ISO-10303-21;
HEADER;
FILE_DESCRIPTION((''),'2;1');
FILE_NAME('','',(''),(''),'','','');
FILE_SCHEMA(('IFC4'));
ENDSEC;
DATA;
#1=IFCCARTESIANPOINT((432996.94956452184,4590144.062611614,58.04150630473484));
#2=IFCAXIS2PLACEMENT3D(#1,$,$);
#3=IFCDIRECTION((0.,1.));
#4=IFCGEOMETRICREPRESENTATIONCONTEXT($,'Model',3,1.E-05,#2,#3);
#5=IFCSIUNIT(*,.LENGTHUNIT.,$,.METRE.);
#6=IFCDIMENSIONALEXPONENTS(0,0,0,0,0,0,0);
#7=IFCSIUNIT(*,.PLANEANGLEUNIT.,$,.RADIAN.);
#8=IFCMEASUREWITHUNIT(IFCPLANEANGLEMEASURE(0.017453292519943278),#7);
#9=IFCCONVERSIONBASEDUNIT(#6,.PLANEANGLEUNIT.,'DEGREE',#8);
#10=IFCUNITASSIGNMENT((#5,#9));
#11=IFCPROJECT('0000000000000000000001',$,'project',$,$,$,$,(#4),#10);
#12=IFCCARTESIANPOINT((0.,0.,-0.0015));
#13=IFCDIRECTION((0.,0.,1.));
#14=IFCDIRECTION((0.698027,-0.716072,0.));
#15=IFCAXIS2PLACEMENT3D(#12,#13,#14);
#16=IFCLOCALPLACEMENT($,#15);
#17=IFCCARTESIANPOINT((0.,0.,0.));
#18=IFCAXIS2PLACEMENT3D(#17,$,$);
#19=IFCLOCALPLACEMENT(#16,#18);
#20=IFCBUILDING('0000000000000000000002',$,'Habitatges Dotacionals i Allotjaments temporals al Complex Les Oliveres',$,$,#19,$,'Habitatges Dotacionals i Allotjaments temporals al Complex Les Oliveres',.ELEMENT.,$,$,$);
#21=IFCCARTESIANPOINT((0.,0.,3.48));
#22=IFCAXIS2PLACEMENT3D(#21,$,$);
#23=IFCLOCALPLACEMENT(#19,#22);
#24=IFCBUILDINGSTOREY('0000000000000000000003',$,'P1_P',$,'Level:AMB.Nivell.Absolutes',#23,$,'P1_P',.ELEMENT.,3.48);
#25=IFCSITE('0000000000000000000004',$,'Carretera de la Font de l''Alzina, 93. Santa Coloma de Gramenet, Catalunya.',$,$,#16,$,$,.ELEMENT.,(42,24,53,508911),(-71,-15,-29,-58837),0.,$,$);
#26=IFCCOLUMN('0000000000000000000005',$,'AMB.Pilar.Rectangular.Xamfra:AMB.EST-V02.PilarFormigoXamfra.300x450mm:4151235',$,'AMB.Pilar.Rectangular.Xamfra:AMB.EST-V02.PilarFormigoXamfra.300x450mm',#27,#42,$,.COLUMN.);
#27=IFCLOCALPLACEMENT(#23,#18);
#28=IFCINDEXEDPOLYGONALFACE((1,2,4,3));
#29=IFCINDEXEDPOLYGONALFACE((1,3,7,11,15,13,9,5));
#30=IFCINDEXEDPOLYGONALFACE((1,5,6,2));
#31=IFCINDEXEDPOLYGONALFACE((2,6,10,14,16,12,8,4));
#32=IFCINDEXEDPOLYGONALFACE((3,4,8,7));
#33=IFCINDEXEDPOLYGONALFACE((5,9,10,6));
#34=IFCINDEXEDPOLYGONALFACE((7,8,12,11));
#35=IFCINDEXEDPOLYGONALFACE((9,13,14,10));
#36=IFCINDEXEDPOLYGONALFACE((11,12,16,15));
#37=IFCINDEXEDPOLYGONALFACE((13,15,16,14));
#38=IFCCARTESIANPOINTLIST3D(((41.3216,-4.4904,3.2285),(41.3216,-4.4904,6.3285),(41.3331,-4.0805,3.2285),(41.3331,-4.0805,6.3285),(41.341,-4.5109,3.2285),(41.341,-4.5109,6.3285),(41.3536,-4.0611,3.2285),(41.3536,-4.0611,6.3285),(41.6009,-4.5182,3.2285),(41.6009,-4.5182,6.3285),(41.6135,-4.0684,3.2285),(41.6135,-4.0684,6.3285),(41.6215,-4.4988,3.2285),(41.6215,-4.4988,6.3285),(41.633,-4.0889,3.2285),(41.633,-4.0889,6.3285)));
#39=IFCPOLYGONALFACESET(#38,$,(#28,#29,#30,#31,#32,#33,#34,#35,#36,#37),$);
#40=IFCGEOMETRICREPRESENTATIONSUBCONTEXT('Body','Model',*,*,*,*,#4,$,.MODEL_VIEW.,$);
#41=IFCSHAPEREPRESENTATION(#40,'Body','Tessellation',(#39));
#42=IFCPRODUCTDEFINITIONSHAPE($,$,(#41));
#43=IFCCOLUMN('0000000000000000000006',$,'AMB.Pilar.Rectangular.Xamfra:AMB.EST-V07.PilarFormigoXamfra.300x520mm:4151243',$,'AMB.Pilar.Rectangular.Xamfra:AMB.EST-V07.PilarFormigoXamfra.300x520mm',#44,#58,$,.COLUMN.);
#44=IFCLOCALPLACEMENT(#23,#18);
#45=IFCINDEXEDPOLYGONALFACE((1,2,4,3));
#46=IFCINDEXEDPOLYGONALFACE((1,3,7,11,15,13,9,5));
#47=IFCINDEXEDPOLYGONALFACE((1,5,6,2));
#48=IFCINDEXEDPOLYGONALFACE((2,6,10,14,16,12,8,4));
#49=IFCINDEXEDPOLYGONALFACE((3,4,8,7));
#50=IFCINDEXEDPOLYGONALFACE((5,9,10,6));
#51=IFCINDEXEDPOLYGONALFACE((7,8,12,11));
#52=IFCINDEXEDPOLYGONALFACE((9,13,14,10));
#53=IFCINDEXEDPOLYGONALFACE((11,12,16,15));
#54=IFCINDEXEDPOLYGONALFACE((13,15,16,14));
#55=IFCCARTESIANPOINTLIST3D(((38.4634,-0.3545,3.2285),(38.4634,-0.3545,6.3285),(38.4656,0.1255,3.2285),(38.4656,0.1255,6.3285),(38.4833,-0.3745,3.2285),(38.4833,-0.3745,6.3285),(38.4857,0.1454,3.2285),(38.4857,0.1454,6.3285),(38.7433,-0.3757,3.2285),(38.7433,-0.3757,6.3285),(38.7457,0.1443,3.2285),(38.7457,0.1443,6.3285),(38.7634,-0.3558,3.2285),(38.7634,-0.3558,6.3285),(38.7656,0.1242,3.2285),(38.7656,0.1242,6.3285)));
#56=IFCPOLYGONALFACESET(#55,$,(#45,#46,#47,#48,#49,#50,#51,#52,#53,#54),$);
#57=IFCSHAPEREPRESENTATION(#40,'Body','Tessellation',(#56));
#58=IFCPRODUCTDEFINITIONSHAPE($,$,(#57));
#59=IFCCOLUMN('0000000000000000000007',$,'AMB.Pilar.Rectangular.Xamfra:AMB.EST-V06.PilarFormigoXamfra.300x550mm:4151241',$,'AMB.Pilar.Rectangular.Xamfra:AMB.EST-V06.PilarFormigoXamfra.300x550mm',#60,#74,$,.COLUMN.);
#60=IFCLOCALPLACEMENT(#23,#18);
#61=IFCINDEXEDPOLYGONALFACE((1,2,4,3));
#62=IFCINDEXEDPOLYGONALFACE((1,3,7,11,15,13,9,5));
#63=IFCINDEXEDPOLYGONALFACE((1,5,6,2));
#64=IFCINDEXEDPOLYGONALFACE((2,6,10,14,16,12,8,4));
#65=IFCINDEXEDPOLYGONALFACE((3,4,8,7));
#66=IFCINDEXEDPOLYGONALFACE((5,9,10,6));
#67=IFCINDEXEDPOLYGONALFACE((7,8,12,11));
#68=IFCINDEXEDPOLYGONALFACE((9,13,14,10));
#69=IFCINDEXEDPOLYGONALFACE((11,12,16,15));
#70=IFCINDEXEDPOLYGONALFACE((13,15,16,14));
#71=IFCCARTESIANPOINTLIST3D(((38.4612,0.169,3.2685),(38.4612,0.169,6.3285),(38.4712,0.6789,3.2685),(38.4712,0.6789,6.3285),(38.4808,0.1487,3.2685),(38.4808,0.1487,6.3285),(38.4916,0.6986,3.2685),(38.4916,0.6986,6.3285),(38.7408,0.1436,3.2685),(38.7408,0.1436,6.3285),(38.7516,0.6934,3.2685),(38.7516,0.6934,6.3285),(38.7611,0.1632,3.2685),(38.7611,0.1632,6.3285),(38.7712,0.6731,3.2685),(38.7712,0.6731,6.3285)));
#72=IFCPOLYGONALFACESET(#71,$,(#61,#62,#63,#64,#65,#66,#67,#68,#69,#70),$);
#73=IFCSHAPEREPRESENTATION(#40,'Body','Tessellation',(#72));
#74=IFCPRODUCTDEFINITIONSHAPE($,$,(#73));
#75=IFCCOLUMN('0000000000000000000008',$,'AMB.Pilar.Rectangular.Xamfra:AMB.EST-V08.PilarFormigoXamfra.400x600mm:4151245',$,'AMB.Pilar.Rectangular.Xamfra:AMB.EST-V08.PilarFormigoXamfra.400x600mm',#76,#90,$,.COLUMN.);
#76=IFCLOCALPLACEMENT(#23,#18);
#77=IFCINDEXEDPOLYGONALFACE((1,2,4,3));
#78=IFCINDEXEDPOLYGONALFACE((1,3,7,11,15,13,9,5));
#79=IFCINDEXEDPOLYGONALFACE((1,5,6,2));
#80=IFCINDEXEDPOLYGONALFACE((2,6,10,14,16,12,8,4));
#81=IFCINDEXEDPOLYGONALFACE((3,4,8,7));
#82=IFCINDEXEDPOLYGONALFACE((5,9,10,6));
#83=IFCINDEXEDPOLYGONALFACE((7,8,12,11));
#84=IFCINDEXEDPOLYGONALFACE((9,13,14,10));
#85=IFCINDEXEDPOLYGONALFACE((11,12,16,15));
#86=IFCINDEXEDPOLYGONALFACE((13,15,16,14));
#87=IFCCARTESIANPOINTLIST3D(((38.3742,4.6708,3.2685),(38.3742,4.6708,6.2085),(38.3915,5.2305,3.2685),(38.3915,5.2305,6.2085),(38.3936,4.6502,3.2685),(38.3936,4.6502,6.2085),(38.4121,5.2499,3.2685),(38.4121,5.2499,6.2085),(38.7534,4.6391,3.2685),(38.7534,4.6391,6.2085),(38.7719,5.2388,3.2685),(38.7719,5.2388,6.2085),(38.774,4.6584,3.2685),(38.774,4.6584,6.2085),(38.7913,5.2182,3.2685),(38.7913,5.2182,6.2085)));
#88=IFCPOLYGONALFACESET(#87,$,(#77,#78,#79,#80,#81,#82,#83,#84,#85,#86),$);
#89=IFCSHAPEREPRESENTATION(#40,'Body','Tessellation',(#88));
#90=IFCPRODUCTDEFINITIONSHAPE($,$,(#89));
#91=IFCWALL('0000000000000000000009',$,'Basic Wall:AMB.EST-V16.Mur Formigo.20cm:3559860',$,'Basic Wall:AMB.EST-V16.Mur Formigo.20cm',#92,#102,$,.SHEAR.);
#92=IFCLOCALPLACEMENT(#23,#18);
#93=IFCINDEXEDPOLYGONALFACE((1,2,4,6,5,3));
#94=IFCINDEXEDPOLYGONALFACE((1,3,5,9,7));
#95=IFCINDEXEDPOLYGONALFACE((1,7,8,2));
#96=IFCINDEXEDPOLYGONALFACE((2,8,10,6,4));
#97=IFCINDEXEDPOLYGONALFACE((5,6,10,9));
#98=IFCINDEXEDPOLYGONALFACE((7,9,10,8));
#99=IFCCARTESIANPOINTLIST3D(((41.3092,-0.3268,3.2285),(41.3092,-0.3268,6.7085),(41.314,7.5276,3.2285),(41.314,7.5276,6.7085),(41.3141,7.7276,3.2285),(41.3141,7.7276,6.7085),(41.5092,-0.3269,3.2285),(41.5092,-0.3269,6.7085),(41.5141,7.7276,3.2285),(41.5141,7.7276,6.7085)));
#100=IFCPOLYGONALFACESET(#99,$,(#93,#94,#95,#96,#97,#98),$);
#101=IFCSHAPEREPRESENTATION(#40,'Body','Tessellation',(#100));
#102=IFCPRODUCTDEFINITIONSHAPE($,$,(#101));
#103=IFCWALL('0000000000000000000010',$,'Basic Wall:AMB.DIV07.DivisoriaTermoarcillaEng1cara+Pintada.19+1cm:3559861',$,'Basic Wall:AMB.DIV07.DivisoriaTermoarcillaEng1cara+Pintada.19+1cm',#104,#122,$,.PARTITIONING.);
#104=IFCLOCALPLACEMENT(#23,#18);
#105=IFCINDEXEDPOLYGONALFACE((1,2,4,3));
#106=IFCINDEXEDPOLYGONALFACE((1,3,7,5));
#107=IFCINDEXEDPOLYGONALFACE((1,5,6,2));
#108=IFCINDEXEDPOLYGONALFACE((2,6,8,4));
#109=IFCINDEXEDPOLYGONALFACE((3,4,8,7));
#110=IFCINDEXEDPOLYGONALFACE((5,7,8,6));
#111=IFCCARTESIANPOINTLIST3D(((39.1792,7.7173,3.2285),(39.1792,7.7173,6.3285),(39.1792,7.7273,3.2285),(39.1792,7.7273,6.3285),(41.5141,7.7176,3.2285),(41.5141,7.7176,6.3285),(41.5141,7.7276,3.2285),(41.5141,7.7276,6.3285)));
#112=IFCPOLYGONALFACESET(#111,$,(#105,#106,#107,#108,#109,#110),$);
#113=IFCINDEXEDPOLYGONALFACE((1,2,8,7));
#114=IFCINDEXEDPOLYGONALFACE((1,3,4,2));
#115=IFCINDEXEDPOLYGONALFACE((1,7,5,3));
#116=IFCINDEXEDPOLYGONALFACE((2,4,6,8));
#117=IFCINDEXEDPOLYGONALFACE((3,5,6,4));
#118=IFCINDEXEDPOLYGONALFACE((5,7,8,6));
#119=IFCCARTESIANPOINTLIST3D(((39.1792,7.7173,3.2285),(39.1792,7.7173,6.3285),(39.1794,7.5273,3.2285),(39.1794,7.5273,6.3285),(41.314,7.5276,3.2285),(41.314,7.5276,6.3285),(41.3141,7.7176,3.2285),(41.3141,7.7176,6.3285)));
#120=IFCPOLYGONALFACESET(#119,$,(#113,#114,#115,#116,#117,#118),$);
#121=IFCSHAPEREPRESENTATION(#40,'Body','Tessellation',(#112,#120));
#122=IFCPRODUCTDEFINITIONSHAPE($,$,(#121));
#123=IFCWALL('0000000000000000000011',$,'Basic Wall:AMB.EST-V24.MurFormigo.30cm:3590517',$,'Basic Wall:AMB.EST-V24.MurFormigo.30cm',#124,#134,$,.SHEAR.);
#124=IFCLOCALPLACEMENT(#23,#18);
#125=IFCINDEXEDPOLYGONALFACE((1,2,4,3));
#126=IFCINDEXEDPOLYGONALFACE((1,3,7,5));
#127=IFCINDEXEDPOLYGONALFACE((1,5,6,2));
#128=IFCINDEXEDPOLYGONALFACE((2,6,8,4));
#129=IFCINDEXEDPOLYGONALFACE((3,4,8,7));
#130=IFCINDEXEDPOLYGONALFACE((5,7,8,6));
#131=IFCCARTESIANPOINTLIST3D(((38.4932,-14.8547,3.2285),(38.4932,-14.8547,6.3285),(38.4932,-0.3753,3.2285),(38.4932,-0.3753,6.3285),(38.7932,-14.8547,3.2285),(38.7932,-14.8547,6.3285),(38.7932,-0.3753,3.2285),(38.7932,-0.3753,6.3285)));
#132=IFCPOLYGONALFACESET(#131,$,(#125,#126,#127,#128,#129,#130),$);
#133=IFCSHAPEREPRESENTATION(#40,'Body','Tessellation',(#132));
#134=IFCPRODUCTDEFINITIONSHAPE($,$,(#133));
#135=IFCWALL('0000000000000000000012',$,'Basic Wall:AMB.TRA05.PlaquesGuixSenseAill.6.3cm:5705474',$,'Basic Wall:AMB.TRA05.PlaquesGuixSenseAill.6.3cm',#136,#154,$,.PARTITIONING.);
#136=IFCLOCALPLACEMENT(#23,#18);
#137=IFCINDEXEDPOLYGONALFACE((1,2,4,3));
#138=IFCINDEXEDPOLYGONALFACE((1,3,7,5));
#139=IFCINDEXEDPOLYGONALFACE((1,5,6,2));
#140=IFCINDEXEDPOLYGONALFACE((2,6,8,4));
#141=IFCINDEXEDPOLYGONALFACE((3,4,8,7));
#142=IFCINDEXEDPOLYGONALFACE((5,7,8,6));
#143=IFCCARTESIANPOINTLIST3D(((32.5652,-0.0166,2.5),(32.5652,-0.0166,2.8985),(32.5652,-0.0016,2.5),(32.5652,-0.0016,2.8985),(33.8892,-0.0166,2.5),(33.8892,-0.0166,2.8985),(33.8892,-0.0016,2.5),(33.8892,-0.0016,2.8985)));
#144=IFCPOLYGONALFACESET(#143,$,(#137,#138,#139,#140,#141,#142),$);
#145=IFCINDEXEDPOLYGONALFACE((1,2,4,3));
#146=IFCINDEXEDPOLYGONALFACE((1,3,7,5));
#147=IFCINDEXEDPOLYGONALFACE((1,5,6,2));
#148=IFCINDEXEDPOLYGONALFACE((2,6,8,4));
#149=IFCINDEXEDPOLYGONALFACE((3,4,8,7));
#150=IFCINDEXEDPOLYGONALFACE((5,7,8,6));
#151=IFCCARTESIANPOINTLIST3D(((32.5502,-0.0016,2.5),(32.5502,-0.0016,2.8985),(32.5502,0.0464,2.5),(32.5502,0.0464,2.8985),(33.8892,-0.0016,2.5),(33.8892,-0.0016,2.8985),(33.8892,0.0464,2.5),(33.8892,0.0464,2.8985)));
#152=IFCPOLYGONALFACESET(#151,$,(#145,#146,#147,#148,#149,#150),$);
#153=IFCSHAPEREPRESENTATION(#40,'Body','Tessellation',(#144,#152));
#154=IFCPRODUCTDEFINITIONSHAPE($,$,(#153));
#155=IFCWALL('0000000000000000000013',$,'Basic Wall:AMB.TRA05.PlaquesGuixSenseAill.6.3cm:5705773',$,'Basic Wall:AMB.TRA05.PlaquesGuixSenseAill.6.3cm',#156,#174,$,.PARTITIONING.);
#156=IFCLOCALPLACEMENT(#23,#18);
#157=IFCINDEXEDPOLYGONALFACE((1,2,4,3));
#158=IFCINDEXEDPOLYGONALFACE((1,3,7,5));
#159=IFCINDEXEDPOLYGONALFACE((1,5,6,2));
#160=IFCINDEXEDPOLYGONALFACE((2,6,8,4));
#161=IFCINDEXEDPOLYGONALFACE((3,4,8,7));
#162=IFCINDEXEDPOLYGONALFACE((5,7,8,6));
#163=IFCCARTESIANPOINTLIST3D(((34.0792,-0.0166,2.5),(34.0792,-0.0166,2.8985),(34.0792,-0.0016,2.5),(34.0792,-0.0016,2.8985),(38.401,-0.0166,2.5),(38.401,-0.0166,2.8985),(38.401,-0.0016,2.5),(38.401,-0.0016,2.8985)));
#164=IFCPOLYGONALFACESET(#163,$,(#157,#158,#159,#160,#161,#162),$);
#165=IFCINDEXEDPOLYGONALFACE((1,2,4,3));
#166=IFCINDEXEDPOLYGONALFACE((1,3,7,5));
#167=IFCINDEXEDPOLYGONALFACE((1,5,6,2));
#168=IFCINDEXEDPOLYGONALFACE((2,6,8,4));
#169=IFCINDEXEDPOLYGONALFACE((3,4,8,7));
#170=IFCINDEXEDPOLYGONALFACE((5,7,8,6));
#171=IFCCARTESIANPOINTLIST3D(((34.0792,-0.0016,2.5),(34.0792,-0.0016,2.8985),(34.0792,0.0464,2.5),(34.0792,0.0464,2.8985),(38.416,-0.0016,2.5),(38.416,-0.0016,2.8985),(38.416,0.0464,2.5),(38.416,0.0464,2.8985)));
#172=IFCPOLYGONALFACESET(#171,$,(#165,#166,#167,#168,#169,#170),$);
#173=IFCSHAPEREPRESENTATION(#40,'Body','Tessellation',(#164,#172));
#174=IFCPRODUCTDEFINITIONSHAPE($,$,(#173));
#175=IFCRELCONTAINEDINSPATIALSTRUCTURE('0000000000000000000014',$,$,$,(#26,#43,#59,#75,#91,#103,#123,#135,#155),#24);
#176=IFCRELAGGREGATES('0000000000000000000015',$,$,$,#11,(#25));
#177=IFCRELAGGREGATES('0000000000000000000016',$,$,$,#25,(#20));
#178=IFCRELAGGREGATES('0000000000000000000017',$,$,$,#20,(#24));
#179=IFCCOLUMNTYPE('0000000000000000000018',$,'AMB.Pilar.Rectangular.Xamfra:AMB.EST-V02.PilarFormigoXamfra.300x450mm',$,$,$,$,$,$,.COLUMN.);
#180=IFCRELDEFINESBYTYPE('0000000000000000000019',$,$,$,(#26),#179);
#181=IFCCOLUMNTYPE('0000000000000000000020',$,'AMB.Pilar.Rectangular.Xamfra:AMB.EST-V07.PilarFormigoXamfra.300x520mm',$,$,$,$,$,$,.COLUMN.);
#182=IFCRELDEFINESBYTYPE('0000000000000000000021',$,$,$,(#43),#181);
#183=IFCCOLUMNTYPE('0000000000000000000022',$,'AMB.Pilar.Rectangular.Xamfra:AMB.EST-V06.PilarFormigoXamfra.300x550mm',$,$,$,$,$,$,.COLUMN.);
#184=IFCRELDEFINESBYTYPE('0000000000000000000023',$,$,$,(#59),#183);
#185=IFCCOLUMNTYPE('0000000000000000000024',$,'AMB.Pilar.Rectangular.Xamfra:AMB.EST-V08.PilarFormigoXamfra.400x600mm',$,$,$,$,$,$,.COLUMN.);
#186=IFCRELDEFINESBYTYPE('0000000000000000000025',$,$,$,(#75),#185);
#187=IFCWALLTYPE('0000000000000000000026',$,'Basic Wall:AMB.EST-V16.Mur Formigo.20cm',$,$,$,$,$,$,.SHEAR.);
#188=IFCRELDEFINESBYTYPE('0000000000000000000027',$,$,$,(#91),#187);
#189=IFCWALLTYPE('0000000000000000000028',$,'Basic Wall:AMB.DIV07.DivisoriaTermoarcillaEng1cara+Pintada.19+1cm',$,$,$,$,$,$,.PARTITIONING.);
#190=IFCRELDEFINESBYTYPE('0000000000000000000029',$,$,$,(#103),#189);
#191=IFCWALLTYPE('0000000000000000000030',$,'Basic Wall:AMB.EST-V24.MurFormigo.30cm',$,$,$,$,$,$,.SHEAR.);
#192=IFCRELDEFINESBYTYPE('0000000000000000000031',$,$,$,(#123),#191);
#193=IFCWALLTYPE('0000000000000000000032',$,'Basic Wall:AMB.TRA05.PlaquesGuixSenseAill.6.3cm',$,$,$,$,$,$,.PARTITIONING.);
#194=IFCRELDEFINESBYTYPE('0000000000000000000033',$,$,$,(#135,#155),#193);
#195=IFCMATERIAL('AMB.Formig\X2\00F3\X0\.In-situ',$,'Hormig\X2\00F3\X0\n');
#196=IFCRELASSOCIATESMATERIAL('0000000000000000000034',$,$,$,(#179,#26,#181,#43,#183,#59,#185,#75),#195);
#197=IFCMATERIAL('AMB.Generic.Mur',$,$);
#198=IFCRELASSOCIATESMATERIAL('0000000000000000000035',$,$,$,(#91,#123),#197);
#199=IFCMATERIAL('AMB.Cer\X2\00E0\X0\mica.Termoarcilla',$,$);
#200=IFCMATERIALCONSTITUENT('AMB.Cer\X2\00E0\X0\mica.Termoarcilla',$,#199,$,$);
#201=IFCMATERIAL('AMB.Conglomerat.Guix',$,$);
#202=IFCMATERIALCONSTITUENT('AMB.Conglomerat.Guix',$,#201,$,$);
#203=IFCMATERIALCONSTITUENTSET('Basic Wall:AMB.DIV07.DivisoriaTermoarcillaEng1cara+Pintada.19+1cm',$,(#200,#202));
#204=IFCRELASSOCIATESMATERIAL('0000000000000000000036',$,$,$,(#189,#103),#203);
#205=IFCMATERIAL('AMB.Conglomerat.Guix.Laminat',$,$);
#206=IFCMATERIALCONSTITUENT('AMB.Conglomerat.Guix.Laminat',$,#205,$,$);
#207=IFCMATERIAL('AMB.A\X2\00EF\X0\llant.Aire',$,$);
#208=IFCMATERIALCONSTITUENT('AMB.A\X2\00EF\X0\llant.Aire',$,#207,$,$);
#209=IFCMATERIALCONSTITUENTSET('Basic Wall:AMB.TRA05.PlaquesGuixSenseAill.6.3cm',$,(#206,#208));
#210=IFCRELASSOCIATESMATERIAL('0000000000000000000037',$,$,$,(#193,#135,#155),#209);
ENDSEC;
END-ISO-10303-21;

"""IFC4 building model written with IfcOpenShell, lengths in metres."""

from ifc_helpers import new_model, entity, si_unit, converted_unit, direction, frame, origin, place, context, subcontext, project, spatial, indexed_curve, outline, extrude, source, transform, mapped, material, constituent, constituent_set, type_object, type_shapes, element, save


model = new_model("IFC4")

# Units and contexts
model_context = context("Model", 3, precision=1e-05, world=frame((432996.94956452184, 4590144.062611614, 58.04150630473484)), true_north=direction((0.0, 1.0)))
body_context = subcontext(model_context, "Body", "Model", "MODEL_VIEW")
ifc_project = project(units=[si_unit("LENGTHUNIT", "METRE"), converted_unit("PLANEANGLEUNIT", "DEGREE", entity("IfcPlaneAngleMeasure", 0.017453292519943278), si_unit("PLANEANGLEUNIT", "RADIAN"), dimensions=[0, 0, 0, 0, 0, 0, 0])], contexts=[model_context])

# Site, building, storey
site_placement = place(None, frame((0.0, 0.0, -0.0015), z_axis=(0.0, 0.0, 1.0), x_axis=(0.698027, -0.716072, 0.0)))
site = spatial("IfcSite", under=ifc_project, at=site_placement, Name="Carretera de la Font de l'Alzina, 93. Santa Coloma de Gramenet, Catalunya.", CompositionType="ELEMENT", RefLatitude=(42, 24, 53, 508911), RefLongitude=(-71, -15, -29, -58837), RefElevation=0.0)
building_placement = place(site_placement, origin())
building = spatial("IfcBuilding", under=site, at=building_placement, Name="Habitatges Dotacionals i Allotjaments temporals al Complex Les Oliveres", LongName="Habitatges Dotacionals i Allotjaments temporals al Complex Les Oliveres", CompositionType="ELEMENT")
storey_placement = place(building_placement, frame((0.0, 0.0, 3.48)))
storey = spatial("IfcBuildingStorey", under=building, at=storey_placement, Name="P1_P", ObjectType="Level:AMB.Nivell.Absolutes", LongName="P1_P", CompositionType="ELEMENT", Elevation=3.48)

# Columns
ifc_material_1 = material(Name="AMB.Formigó.In-situ", Category="Hormigón")
column_type_1 = type_object("IfcColumnType", Name="AMB.Pilar.Rectangular.Xamfra:AMB.EST-V02.PilarFormigoXamfra.300x450mm", PredefinedType="COLUMN", material=ifc_material_1)
shared_shape_1 = source(origin(), body_context, "Body", "SweptSolid", [
    extrude(outline(indexed_curve([(-0.13, -0.225), (0.13, -0.225), (0.15, -0.205), (0.15, 0.205), (0.13, 0.225), (-0.13, 0.225), (-0.15, 0.205), (-0.15, -0.205), (-0.13, -0.225)], self_intersect=False)), frame((0.0, 0.0, 6.7085), z_axis=(0.0, 0.0, 1.0), x_axis=(-1.0, 0.0, 0.0)), (0.0, 0.0, 1.0), 3.1),
])
type_shapes(column_type_1, [shared_shape_1])
column_1_placement = place(storey_placement, frame((41.4773, -4.2896, -3.48), z_axis=(0.0, 0.0, 1.0), x_axis=(0.999609, -0.027977, 0.0)))
element("IfcColumn", 1, at=column_1_placement, inside=storey, type_object=column_type_1, material=ifc_material_1, Name="AMB.Pilar.Rectangular.Xamfra:AMB.EST-V02.PilarFormigoXamfra.300x450mm:4151235", ObjectType="AMB.Pilar.Rectangular.Xamfra:AMB.EST-V02.PilarFormigoXamfra.300x450mm", PredefinedType="COLUMN", context=body_context, shape_type="MappedRepresentation", body=[
    mapped(shared_shape_1, transform((0.0, 0.0, 0.0), scale=1.0)),
])
column_type_2 = type_object("IfcColumnType", Name="AMB.Pilar.Rectangular.Xamfra:AMB.EST-V07.PilarFormigoXamfra.300x520mm", PredefinedType="COLUMN", material=ifc_material_1)
shared_shape_2 = source(origin(), body_context, "Body", "SweptSolid", [
    extrude(outline(indexed_curve([(-0.13, -0.26), (0.13, -0.26), (0.15, -0.24), (0.15, 0.24), (0.13, 0.26), (-0.13, 0.26), (-0.15, 0.24), (-0.15, -0.24), (-0.13, -0.26)], self_intersect=False)), frame((0.0, 0.0, 6.7085), z_axis=(0.0, 0.0, 1.0), x_axis=(-1.0, 0.0, 0.0)), (0.0, 0.0, 1.0), 3.1),
])
type_shapes(column_type_2, [shared_shape_2])
column_2_placement = place(storey_placement, frame((38.6145, -0.1151, -3.48), z_axis=(0.0, 0.0, 1.0), x_axis=(0.999989, -0.004594, 0.0)))
element("IfcColumn", 2, at=column_2_placement, inside=storey, type_object=column_type_2, material=ifc_material_1, Name="AMB.Pilar.Rectangular.Xamfra:AMB.EST-V07.PilarFormigoXamfra.300x520mm:4151243", ObjectType="AMB.Pilar.Rectangular.Xamfra:AMB.EST-V07.PilarFormigoXamfra.300x520mm", PredefinedType="COLUMN", context=body_context, shape_type="MappedRepresentation", body=[
    mapped(shared_shape_2, transform((0.0, 0.0, 0.0), scale=1.0)),
])
column_type_3 = type_object("IfcColumnType", Name="AMB.Pilar.Rectangular.Xamfra:AMB.EST-V06.PilarFormigoXamfra.300x550mm", PredefinedType="COLUMN", material=ifc_material_1)
shared_shape_3 = source(origin(), body_context, "Body", "SweptSolid", [
    extrude(outline(indexed_curve([(-0.13, -0.275), (0.13, -0.275), (0.15, -0.255), (0.15, 0.255), (0.13, 0.275), (-0.13, 0.275), (-0.15, 0.255), (-0.15, -0.255), (-0.13, -0.275)], self_intersect=False)), frame((0.0, 0.0, 6.7485), z_axis=(0.0, 0.0, 1.0), x_axis=(-1.0, 0.0, 0.0)), (0.0, 0.0, 1.0), 3.06),
])
type_shapes(column_type_3, [shared_shape_3])
column_3_placement = place(storey_placement, frame((38.6162, 0.4211, -3.48), z_axis=(0.0, 0.0, 1.0), x_axis=(0.999807, -0.019634, 0.0)))
element("IfcColumn", 3, at=column_3_placement, inside=storey, type_object=column_type_3, material=ifc_material_1, Name="AMB.Pilar.Rectangular.Xamfra:AMB.EST-V06.PilarFormigoXamfra.300x550mm:4151241", ObjectType="AMB.Pilar.Rectangular.Xamfra:AMB.EST-V06.PilarFormigoXamfra.300x550mm", PredefinedType="COLUMN", context=body_context, shape_type="MappedRepresentation", body=[
    mapped(shared_shape_3, transform((0.0, 0.0, 0.0), scale=1.0)),
])
column_type_4 = type_object("IfcColumnType", Name="AMB.Pilar.Rectangular.Xamfra:AMB.EST-V08.PilarFormigoXamfra.400x600mm", PredefinedType="COLUMN", material=ifc_material_1)
shared_shape_4 = source(origin(), body_context, "Body", "SweptSolid", [
    extrude(outline(indexed_curve([(-0.18, -0.3), (0.18, -0.3), (0.2, -0.28), (0.2, 0.28), (0.18, 0.3), (-0.18, 0.3), (-0.2, 0.28), (-0.2, -0.28), (-0.18, -0.3)], self_intersect=False)), frame((0.0, 0.0, 6.7485), z_axis=(0.0, 0.0, 1.0), x_axis=(-1.0, 0.0, 0.0)), (0.0, 0.0, 1.0), 2.94),
])
type_shapes(column_type_4, [shared_shape_4])
column_4_placement = place(storey_placement, frame((38.5827, 4.9445, -3.48), z_axis=(0.0, 0.0, 1.0), x_axis=(-0.999523, 0.030873, 0.0)))
element("IfcColumn", 4, at=column_4_placement, inside=storey, type_object=column_type_4, material=ifc_material_1, Name="AMB.Pilar.Rectangular.Xamfra:AMB.EST-V08.PilarFormigoXamfra.400x600mm:4151245", ObjectType="AMB.Pilar.Rectangular.Xamfra:AMB.EST-V08.PilarFormigoXamfra.400x600mm", PredefinedType="COLUMN", context=body_context, shape_type="MappedRepresentation", body=[
    mapped(shared_shape_4, transform((0.0, 0.0, 0.0), scale=1.0)),
])

# Walls
ifc_material_2 = material(Name="AMB.Generic.Mur")
wall_type_1 = type_object("IfcWallType", Name="Basic Wall:AMB.EST-V16.Mur Formigo.20cm", PredefinedType="SHEAR")
wall_1_placement = place(storey_placement, frame((41.4092, -0.3269, 3.2285), z_axis=(0.0, 0.0, 1.0), x_axis=(0.000611, 1.0, 0.0)))
element("IfcWall", 5, at=wall_1_placement, inside=storey, type_object=wall_type_1, material=ifc_material_2, Name="Basic Wall:AMB.EST-V16.Mur Formigo.20cm:3559860", ObjectType="Basic Wall:AMB.EST-V16.Mur Formigo.20cm", PredefinedType="SHEAR", context=body_context, shape_type="SweptSolid", body=[
    extrude(outline(indexed_curve([(8.0546, -0.1), (8.0544, 0.1), (7.8544, 0.1), (0.0, 0.1), (0.0, -0.1), (8.0546, -0.1)], self_intersect=False)), origin(), (0.0, 0.0, 1.0), 3.48),
])
ifc_material_3 = material(Name="AMB.Ceràmica.Termoarcilla")
ifc_constituent_1 = constituent(ifc_material_3, Name="AMB.Ceràmica.Termoarcilla")
ifc_material_4 = material(Name="AMB.Conglomerat.Guix")
ifc_constituent_2 = constituent(ifc_material_4, Name="AMB.Conglomerat.Guix")
ifc_constituent_set_1 = constituent_set(constituents=[ifc_constituent_1, ifc_constituent_2], Name="Basic Wall:AMB.DIV07.DivisoriaTermoarcillaEng1cara+Pintada.19+1cm")
wall_type_2 = type_object("IfcWallType", Name="Basic Wall:AMB.DIV07.DivisoriaTermoarcillaEng1cara+Pintada.19+1cm", PredefinedType="PARTITIONING", material=ifc_constituent_set_1)
wall_2_placement = place(storey_placement, frame((41.3141, 7.6276, 3.2285), z_axis=(0.0, 0.0, 1.0), x_axis=(-1.0, -0.000147, 0.0)))
element("IfcWall", 6, at=wall_2_placement, inside=storey, type_object=wall_type_2, material=ifc_constituent_set_1, Name="Basic Wall:AMB.DIV07.DivisoriaTermoarcillaEng1cara+Pintada.19+1cm:3559861", ObjectType="Basic Wall:AMB.DIV07.DivisoriaTermoarcillaEng1cara+Pintada.19+1cm", PredefinedType="PARTITIONING", context=body_context, shape_type="SweptSolid", body=[
    extrude(outline(indexed_curve([(-0.0061, -1.1674), (0.0039, -1.1674), (0.0061, 1.1674), (-0.0039, 1.1675), (-0.0061, -1.1674)], self_intersect=False)), frame((0.9675, -0.095, 0.0), z_axis=(0.0, 0.0, 1.0), x_axis=(-0.00093, 1.0, 0.0)), (0.0, 0.0, 1.0), 3.1),
    extrude(outline(indexed_curve([(-0.0942, -1.0674), (0.0958, -1.0674), (0.0942, 1.0675), (-0.0958, 1.0672), (-0.0942, -1.0674)], self_intersect=False)), frame((1.0674, 0.005, 0.0), z_axis=(0.0, 0.0, 1.0), x_axis=(-0.000759, -1.0, 0.0)), (0.0, 0.0, 1.0), 3.1),
])

# Walls
wall_type_3 = type_object("IfcWallType", Name="Basic Wall:AMB.EST-V24.MurFormigo.30cm", PredefinedType="SHEAR")
wall_3_placement = place(storey_placement, frame((38.6432, -0.3753, 3.2285), z_axis=(0.0, 0.0, 1.0), x_axis=(0.0, -1.0, 0.0)))
element("IfcWall", 7, at=wall_3_placement, inside=storey, type_object=wall_type_3, material=ifc_material_2, Name="Basic Wall:AMB.EST-V24.MurFormigo.30cm:3590517", ObjectType="Basic Wall:AMB.EST-V24.MurFormigo.30cm", PredefinedType="SHEAR", context=body_context, shape_type="SweptSolid", body=[
    extrude(outline(indexed_curve([(14.4794, 0.15), (0.0, 0.15), (0.0, -0.15), (14.4794, -0.15), (14.4794, 0.15)], self_intersect=False)), origin(), (0.0, 0.0, 1.0), 3.1),
])
ifc_material_5 = material(Name="AMB.Conglomerat.Guix.Laminat")
ifc_constituent_3 = constituent(ifc_material_5, Name="AMB.Conglomerat.Guix.Laminat")
ifc_material_6 = material(Name="AMB.Aïllant.Aire")
ifc_constituent_4 = constituent(ifc_material_6, Name="AMB.Aïllant.Aire")
ifc_constituent_set_2 = constituent_set(constituents=[ifc_constituent_3, ifc_constituent_4], Name="Basic Wall:AMB.TRA05.PlaquesGuixSenseAill.6.3cm")
wall_type_4 = type_object("IfcWallType", Name="Basic Wall:AMB.TRA05.PlaquesGuixSenseAill.6.3cm", PredefinedType="PARTITIONING", material=ifc_constituent_set_2)
wall_4_placement = place(storey_placement, frame((33.8792, 0.0149, 2.5), z_axis=(0.0, 0.0, 1.0), x_axis=(-1.0, 0.0, 0.0)))
element("IfcWall", 8, at=wall_4_placement, inside=storey, type_object=wall_type_4, material=ifc_constituent_set_2, Name="Basic Wall:AMB.TRA05.PlaquesGuixSenseAill.6.3cm:5705474", ObjectType="Basic Wall:AMB.TRA05.PlaquesGuixSenseAill.6.3cm", PredefinedType="PARTITIONING", context=body_context, shape_type="SweptSolid", body=[
    extrude(outline(indexed_curve([(-0.0075, -0.662), (0.0075, -0.662), (0.0075, 0.662), (-0.0075, 0.662), (-0.0075, -0.662)], self_intersect=False)), frame((0.652, 0.024, 0.0), z_axis=(0.0, 0.0, 1.0), x_axis=(0.0, -1.0, 0.0)), (0.0, 0.0, 1.0), 0.3985),
    extrude(outline(indexed_curve([(-0.024, -0.6695), (0.024, -0.6695), (0.024, 0.6695), (-0.024, 0.6695), (-0.024, -0.6695)], self_intersect=False)), frame((0.6595, -0.0075, 0.0), z_axis=(0.0, 0.0, 1.0), x_axis=(0.0, 1.0, 0.0)), (0.0, 0.0, 1.0), 0.3985),
])
wall_5_placement = place(storey_placement, frame((38.401, 0.0149, 2.5), z_axis=(0.0, 0.0, 1.0), x_axis=(-1.0, 0.0, 0.0)))
element("IfcWall", 9, at=wall_5_placement, inside=storey, type_object=wall_type_4, material=ifc_constituent_set_2, Name="Basic Wall:AMB.TRA05.PlaquesGuixSenseAill.6.3cm:5705773", ObjectType="Basic Wall:AMB.TRA05.PlaquesGuixSenseAill.6.3cm", PredefinedType="PARTITIONING", context=body_context, shape_type="SweptSolid", body=[
    extrude(outline(indexed_curve([(-0.0075, -2.1609), (0.0075, -2.1609), (0.0075, 2.1609), (-0.0075, 2.1609), (-0.0075, -2.1609)], self_intersect=False)), frame((2.1609, 0.024, 0.0), z_axis=(0.0, 0.0, 1.0), x_axis=(0.0, -1.0, 0.0)), (0.0, 0.0, 1.0), 0.3985),
    extrude(outline(indexed_curve([(-0.024, -2.1684), (0.024, -2.1684), (0.024, 2.1684), (-0.024, 2.1684), (-0.024, -2.1684)], self_intersect=False)), frame((2.1534, -0.0075, 0.0), z_axis=(0.0, 0.0, 1.0), x_axis=(0.0, 1.0, 0.0)), (0.0, 0.0, 1.0), 0.3985),
])

save(model, "model.ifc")
